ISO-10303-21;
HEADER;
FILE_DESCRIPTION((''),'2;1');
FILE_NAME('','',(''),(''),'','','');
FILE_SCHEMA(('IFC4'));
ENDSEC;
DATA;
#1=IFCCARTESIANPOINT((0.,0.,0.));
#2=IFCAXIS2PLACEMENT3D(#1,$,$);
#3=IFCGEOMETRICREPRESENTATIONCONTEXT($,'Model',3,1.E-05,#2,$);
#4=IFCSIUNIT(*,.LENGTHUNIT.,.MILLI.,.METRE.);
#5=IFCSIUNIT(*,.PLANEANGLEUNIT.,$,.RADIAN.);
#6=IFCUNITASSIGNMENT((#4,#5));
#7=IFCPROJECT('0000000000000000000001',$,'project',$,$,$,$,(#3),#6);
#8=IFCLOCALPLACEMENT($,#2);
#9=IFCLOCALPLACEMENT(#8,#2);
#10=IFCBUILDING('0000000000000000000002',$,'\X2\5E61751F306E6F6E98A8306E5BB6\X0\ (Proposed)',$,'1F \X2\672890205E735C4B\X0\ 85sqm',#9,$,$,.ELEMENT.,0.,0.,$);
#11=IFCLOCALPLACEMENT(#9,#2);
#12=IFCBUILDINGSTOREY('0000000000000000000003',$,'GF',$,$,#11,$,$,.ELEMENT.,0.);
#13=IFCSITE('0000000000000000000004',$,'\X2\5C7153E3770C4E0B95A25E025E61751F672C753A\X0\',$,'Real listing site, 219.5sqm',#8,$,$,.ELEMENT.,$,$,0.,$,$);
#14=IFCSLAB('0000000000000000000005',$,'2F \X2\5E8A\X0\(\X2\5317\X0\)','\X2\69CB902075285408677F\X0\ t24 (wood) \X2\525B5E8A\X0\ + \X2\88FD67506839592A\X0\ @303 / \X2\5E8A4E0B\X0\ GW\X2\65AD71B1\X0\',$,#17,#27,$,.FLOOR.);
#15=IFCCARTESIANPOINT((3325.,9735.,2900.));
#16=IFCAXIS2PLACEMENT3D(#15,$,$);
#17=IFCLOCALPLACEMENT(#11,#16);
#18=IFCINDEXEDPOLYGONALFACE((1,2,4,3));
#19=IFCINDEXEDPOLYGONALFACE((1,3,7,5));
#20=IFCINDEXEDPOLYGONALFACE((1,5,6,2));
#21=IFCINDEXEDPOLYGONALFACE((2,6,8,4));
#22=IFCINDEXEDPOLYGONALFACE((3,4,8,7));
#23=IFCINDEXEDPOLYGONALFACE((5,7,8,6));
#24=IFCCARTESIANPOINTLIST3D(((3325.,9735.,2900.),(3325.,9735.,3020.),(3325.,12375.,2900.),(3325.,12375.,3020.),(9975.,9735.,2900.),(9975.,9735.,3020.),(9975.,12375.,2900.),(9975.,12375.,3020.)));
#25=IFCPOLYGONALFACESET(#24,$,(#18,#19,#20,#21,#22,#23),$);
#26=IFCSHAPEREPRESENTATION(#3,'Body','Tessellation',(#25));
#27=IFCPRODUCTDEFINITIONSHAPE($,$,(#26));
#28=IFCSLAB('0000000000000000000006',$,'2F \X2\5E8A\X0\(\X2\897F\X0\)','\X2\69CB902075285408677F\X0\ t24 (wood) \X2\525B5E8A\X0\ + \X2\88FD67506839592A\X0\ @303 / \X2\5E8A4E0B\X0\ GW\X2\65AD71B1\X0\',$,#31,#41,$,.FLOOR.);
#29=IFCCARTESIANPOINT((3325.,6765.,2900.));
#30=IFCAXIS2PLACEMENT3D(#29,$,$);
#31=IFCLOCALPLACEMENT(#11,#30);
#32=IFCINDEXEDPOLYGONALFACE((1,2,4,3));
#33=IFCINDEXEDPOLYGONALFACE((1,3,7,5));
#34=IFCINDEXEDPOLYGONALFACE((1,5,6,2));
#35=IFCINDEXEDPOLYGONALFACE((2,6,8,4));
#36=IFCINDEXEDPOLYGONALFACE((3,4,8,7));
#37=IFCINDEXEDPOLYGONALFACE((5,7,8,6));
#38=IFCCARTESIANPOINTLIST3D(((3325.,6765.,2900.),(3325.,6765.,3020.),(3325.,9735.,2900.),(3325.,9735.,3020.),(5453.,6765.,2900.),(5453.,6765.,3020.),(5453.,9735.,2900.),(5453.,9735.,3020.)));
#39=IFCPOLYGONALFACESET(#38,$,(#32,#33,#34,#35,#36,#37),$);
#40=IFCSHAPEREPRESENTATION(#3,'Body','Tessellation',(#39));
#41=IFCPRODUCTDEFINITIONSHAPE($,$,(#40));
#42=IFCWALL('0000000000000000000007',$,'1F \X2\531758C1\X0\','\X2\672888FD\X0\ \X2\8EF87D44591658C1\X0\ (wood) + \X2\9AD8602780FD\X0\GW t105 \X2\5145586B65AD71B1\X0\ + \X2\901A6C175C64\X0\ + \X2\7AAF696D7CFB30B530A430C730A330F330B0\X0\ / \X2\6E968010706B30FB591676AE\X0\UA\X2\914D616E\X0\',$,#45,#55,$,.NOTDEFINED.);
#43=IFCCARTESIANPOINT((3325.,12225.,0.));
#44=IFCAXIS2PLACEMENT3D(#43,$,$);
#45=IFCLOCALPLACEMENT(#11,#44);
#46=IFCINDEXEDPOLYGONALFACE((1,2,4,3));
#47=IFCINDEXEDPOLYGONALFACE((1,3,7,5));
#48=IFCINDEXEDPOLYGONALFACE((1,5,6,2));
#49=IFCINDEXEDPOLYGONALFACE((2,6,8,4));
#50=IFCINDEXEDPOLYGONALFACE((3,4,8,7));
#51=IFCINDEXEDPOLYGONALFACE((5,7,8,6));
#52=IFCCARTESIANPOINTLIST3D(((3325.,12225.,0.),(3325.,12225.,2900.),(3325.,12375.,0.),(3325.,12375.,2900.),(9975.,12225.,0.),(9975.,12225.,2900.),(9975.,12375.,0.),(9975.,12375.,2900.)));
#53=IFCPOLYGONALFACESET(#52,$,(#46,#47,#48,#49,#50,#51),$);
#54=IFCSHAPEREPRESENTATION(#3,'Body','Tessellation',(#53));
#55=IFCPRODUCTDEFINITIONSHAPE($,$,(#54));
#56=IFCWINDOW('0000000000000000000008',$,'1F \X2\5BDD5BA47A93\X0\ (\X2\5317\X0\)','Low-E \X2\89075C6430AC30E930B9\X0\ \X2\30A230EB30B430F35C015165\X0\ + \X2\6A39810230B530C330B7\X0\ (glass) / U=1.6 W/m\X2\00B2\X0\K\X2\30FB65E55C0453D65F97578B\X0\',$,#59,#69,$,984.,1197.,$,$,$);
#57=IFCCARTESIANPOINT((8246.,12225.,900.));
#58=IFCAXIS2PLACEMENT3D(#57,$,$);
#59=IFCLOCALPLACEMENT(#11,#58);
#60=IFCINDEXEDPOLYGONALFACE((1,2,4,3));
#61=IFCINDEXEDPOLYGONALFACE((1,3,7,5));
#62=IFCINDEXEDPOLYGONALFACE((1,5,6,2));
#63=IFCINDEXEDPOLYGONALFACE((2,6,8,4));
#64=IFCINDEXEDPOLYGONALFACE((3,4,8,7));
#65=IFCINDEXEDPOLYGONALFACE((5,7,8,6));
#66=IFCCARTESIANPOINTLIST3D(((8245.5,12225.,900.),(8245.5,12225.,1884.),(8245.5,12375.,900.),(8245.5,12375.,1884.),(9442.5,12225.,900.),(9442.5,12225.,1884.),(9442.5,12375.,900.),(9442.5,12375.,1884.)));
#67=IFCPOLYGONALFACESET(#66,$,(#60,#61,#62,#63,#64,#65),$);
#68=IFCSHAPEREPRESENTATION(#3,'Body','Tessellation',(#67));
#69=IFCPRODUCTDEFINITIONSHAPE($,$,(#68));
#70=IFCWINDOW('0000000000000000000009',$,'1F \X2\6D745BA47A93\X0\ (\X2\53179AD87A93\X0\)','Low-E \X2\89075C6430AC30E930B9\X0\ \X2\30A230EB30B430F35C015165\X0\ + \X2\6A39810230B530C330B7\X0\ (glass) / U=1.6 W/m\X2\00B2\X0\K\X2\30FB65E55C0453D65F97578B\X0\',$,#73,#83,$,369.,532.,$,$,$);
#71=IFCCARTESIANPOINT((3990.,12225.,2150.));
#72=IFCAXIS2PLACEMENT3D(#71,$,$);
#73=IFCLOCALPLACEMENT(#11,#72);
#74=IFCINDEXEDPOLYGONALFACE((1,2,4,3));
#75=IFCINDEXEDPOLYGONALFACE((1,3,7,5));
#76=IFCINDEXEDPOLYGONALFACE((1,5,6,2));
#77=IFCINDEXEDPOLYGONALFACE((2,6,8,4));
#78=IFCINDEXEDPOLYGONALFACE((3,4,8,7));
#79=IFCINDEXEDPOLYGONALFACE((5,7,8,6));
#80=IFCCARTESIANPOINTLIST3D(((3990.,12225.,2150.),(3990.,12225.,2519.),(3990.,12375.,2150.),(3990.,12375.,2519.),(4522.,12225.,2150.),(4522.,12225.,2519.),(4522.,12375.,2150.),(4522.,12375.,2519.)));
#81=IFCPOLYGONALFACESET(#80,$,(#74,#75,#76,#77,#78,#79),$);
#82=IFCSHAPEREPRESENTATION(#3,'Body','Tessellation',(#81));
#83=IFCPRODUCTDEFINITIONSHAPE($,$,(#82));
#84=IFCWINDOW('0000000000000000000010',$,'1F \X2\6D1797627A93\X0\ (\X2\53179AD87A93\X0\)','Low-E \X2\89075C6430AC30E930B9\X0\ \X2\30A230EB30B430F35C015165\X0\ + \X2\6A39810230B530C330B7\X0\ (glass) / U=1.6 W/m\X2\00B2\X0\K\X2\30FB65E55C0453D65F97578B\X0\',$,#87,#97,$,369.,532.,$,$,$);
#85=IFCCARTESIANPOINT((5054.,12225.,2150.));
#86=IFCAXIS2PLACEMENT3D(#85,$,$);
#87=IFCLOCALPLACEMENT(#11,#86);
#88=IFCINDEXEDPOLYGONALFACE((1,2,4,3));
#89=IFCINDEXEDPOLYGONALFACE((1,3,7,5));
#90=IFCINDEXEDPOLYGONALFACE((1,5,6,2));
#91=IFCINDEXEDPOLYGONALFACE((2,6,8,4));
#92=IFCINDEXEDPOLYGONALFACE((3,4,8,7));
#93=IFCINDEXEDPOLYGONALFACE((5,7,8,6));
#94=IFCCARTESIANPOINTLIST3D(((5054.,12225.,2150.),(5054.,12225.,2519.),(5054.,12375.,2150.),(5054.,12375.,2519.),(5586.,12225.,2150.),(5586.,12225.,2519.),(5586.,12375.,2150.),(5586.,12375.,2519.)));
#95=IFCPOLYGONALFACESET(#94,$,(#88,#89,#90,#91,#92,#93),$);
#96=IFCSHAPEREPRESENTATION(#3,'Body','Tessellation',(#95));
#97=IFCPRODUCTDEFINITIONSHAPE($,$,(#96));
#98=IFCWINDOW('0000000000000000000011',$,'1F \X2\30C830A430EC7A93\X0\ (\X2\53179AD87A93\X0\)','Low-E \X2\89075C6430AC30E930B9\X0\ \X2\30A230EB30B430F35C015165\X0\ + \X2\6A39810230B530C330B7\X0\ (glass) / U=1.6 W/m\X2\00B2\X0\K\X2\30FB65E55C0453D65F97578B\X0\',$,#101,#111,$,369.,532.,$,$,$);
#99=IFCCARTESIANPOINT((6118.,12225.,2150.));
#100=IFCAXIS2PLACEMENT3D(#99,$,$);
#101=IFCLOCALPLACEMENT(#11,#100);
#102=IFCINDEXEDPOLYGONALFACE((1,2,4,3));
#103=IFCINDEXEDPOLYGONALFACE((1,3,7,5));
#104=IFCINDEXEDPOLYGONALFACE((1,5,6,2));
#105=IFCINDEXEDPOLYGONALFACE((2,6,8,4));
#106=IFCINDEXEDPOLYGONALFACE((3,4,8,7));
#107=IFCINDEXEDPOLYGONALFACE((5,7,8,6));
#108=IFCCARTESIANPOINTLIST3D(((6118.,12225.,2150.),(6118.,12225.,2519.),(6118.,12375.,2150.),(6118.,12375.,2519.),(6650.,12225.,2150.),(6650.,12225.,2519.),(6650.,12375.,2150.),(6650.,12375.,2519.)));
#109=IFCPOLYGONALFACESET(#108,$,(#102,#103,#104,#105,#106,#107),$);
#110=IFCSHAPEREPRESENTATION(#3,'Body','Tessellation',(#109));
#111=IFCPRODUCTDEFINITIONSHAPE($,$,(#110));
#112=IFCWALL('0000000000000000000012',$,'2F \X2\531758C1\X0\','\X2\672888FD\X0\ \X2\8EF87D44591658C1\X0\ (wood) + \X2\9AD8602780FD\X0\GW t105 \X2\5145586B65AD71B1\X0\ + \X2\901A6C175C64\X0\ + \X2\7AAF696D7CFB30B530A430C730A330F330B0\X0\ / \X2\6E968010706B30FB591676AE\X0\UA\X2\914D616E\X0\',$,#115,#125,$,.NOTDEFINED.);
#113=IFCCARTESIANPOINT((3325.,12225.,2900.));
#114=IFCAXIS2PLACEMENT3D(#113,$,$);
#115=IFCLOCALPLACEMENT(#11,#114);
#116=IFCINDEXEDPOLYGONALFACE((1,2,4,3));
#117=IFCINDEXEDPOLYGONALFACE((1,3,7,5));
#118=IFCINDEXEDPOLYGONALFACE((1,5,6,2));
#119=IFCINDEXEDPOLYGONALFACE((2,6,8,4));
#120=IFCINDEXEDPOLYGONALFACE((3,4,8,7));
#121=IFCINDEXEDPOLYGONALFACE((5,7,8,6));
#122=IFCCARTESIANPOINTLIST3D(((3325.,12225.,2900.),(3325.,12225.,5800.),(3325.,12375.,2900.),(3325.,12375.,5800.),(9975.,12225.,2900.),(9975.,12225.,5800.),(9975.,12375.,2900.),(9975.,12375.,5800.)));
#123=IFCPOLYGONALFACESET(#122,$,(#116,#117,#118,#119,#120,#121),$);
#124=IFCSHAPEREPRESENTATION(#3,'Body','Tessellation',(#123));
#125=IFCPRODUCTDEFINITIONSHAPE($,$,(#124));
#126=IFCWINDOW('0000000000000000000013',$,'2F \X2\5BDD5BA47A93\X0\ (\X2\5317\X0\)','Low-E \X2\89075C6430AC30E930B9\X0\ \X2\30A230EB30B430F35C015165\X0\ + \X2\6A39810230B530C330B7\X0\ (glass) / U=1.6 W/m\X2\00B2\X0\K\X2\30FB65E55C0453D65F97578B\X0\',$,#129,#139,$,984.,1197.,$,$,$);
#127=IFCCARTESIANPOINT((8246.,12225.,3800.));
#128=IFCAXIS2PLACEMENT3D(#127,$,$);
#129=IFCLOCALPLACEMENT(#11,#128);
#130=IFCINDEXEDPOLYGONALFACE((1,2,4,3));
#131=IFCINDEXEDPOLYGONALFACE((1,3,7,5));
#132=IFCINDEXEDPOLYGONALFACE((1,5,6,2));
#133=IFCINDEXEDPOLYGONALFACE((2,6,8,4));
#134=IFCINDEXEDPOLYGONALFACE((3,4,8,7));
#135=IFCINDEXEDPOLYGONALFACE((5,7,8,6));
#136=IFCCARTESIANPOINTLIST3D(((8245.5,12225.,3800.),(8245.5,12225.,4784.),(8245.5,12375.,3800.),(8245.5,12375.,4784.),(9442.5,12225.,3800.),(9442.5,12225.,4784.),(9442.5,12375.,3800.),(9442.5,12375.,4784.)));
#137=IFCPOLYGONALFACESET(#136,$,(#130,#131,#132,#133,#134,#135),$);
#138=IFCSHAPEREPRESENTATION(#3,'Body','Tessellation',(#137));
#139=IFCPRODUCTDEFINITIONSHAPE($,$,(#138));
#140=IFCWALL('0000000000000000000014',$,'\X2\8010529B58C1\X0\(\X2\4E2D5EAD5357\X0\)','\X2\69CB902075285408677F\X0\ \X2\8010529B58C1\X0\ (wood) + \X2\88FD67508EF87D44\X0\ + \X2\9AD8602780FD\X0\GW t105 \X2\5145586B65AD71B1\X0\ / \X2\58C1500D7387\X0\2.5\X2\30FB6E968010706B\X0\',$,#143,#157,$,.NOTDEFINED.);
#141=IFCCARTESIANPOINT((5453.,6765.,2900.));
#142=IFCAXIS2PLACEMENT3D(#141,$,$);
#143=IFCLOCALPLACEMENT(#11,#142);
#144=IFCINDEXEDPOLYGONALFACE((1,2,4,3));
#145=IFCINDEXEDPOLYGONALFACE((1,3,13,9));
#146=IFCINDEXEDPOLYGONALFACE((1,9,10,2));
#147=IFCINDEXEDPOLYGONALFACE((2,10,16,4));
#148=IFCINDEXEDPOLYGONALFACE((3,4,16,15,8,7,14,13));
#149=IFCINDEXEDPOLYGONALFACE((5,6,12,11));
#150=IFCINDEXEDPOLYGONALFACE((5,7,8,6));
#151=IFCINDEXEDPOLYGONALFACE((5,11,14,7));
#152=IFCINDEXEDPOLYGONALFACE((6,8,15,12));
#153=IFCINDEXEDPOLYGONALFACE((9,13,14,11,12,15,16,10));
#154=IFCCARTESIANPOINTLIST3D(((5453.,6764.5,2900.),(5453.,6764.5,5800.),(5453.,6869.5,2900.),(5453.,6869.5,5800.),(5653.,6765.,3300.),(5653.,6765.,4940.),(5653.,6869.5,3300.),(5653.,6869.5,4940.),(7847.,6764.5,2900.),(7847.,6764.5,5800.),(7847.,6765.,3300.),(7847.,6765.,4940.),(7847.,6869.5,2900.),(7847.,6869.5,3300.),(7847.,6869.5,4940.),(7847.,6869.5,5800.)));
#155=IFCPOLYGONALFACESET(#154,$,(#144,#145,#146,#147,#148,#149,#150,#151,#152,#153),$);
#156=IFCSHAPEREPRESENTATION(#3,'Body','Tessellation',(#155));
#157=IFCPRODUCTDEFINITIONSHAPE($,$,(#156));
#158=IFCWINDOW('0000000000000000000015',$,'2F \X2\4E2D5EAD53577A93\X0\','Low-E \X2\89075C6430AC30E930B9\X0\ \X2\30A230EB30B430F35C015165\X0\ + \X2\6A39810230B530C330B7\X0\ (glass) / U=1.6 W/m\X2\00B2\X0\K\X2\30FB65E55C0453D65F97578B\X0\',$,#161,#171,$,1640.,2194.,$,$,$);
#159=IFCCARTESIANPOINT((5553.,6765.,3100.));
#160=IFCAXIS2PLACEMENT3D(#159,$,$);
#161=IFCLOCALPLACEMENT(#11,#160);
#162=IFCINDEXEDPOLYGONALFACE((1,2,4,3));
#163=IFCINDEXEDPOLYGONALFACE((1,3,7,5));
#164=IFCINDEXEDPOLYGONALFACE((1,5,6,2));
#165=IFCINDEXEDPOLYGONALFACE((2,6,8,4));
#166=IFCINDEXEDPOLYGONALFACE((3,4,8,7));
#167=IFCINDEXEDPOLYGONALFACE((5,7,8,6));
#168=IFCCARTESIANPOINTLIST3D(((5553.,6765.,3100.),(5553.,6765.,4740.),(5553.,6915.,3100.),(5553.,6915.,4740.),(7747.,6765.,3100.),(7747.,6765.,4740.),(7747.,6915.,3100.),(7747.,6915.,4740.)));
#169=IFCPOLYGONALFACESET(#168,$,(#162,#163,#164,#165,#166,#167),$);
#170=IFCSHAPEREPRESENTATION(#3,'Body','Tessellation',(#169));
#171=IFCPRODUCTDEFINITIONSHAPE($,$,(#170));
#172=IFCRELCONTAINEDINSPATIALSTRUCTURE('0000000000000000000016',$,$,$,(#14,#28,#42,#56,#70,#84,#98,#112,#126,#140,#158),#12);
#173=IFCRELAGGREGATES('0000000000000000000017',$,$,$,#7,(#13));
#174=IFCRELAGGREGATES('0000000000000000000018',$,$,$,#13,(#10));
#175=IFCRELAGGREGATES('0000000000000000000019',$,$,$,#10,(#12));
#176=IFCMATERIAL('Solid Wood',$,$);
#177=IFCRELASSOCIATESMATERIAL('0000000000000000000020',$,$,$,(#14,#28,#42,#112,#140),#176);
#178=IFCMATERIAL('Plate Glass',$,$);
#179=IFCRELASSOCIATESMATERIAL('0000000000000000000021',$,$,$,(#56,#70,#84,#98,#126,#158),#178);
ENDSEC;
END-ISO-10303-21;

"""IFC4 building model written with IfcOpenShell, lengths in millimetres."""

from ifc_helpers import new_model, si_unit, frame, frame_2d, origin, place, context, project, spatial, rectangle, extrude, material, element, fill, save


model = new_model("IFC4")

# Units and contexts
model_context = context("Model", 3, precision=1e-05, world=origin())
ifc_project = project(units=[si_unit("LENGTHUNIT", "METRE", prefix="MILLI"), si_unit("PLANEANGLEUNIT", "RADIAN")], contexts=[model_context])

# Site, building, storey
site_placement = place(None, origin())
site = spatial("IfcSite", under=ifc_project, at=site_placement, Name="山口県下関市幡生本町", ObjectType="Real listing site, 219.5sqm", CompositionType="ELEMENT", RefElevation=0.0)
building_placement = place(site_placement, origin())
building = spatial("IfcBuilding", under=site, at=building_placement, Name="幡生の潮風の家 (Proposed)", ObjectType="1F 木造平屋 85sqm", CompositionType="ELEMENT", ElevationOfRefHeight=0.0, ElevationOfTerrain=0.0)
storey_placement = place(building_placement, origin())
storey = spatial("IfcBuildingStorey", under=building, at=storey_placement, Name="GF", CompositionType="ELEMENT", Elevation=0.0)

# Slabs
ifc_material_1 = material(Name="Solid Wood")
slab_1_placement = place(storey_placement, frame((3325.0, 9735.0, 2900.0)))
element("IfcSlab", 1, at=slab_1_placement, inside=storey, material=ifc_material_1, Name="2F 床(北)", Description="構造用合板 t24 (wood) 剛床 + 製材根太 @303 / 床下 GW断熱", PredefinedType="FLOOR", context=model_context, shape_type="SweptSolid", body=[
    extrude(rectangle(XDim=6650.0, YDim=2640.0, at=frame_2d((3325.0, 1320.0))), frame((3325.0, 9735.0, 2900.0)), (0.0, 0.0, 1.0), 120.0),
])
slab_2_placement = place(storey_placement, frame((3325.0, 6765.0, 2900.0)))
element("IfcSlab", 2, at=slab_2_placement, inside=storey, material=ifc_material_1, Name="2F 床(西)", Description="構造用合板 t24 (wood) 剛床 + 製材根太 @303 / 床下 GW断熱", PredefinedType="FLOOR", context=model_context, shape_type="SweptSolid", body=[
    extrude(rectangle(XDim=2128.0, YDim=2970.0, at=frame_2d((1064.0, 1485.0))), frame((3325.0, 6765.0, 2900.0)), (0.0, 0.0, 1.0), 120.0),
])

# Wall, openings, windows
wall_1_placement = place(storey_placement, frame((3325.0, 12225.0, 0.0)))
wall_1 = element("IfcWall", 3, at=wall_1_placement, inside=storey, material=ifc_material_1, Name="1F 北壁", Description="木製 軸組外壁 (wood) + 高性能GW t105 充填断熱 + 通気層 + 窯業系サイディング / 準耐火・外皮UA配慮", PredefinedType="NOTDEFINED", context=model_context, shape_type="SweptSolid", body=[
    extrude(rectangle(XDim=6650.0, YDim=150.0, at=frame_2d((3325.0, 75.0))), frame((3325.0, 12225.0, 0.0)), (0.0, 0.0, 1.0), 2900.0),
])
opening_1_placement = place(storey_placement, frame((8246.0, 12225.0, 900.0)))
opening_1 = element("IfcOpeningElement", 4, at=opening_1_placement, cuts=wall_1, PredefinedType="NOTDEFINED", context=model_context, shape_type="SweptSolid", body=[
    extrude(rectangle(XDim=1197.0, YDim=150.0, at=frame_2d((598.0, 75.0))), frame((8246.0, 12225.0, 900.0)), (0.0, 0.0, 1.0), 984.0),
])
opening_2_placement = place(storey_placement, frame((3990.0, 12225.0, 2150.0)))
opening_2 = element("IfcOpeningElement", 5, at=opening_2_placement, cuts=wall_1, PredefinedType="NOTDEFINED", context=model_context, shape_type="SweptSolid", body=[
    extrude(rectangle(XDim=532.0, YDim=150.0, at=frame_2d((266.0, 75.0))), frame((3990.0, 12225.0, 2150.0)), (0.0, 0.0, 1.0), 369.0),
])
opening_3_placement = place(storey_placement, frame((5054.0, 12225.0, 2150.0)))
opening_3 = element("IfcOpeningElement", 6, at=opening_3_placement, cuts=wall_1, PredefinedType="NOTDEFINED", context=model_context, shape_type="SweptSolid", body=[
    extrude(rectangle(XDim=532.0, YDim=150.0, at=frame_2d((266.0, 75.0))), frame((5054.0, 12225.0, 2150.0)), (0.0, 0.0, 1.0), 369.0),
])
opening_4_placement = place(storey_placement, frame((6118.0, 12225.0, 2150.0)))
opening_4 = element("IfcOpeningElement", 7, at=opening_4_placement, cuts=wall_1, PredefinedType="NOTDEFINED", context=model_context, shape_type="SweptSolid", body=[
    extrude(rectangle(XDim=532.0, YDim=150.0, at=frame_2d((266.0, 75.0))), frame((6118.0, 12225.0, 2150.0)), (0.0, 0.0, 1.0), 369.0),
])
ifc_material_2 = material(Name="Plate Glass")
window_1_placement = place(storey_placement, frame((8246.0, 12225.0, 900.0)))
window_1 = element("IfcWindow", 8, at=window_1_placement, inside=storey, material=ifc_material_2, Name="1F 寝室窓 (北)", Description="Low-E 複層ガラス アルゴン封入 + 樹脂サッシ (glass) / U=1.6 W/m²K・日射取得型", OverallHeight=984.0, OverallWidth=1197.0, context=model_context, shape_type="SweptSolid", body=[
    extrude(rectangle(XDim=1197.0, YDim=150.0, at=frame_2d((598.0, 75.0))), frame((8246.0, 12225.0, 900.0)), (0.0, 0.0, 1.0), 984.0),
])
fill(opening_1, window_1)
window_2_placement = place(storey_placement, frame((3990.0, 12225.0, 2150.0)))
window_2 = element("IfcWindow", 9, at=window_2_placement, inside=storey, material=ifc_material_2, Name="1F 浴室窓 (北高窓)", Description="Low-E 複層ガラス アルゴン封入 + 樹脂サッシ (glass) / U=1.6 W/m²K・日射取得型", OverallHeight=369.0, OverallWidth=532.0, context=model_context, shape_type="SweptSolid", body=[
    extrude(rectangle(XDim=532.0, YDim=150.0, at=frame_2d((266.0, 75.0))), frame((3990.0, 12225.0, 2150.0)), (0.0, 0.0, 1.0), 369.0),
])
fill(opening_2, window_2)
window_3_placement = place(storey_placement, frame((5054.0, 12225.0, 2150.0)))
window_3 = element("IfcWindow", 10, at=window_3_placement, inside=storey, material=ifc_material_2, Name="1F 洗面窓 (北高窓)", Description="Low-E 複層ガラス アルゴン封入 + 樹脂サッシ (glass) / U=1.6 W/m²K・日射取得型", OverallHeight=369.0, OverallWidth=532.0, context=model_context, shape_type="SweptSolid", body=[
    extrude(rectangle(XDim=532.0, YDim=150.0, at=frame_2d((266.0, 75.0))), frame((5054.0, 12225.0, 2150.0)), (0.0, 0.0, 1.0), 369.0),
])
fill(opening_3, window_3)
window_4_placement = place(storey_placement, frame((6118.0, 12225.0, 2150.0)))
window_4 = element("IfcWindow", 11, at=window_4_placement, inside=storey, material=ifc_material_2, Name="1F トイレ窓 (北高窓)", Description="Low-E 複層ガラス アルゴン封入 + 樹脂サッシ (glass) / U=1.6 W/m²K・日射取得型", OverallHeight=369.0, OverallWidth=532.0, context=model_context, shape_type="SweptSolid", body=[
    extrude(rectangle(XDim=532.0, YDim=150.0, at=frame_2d((266.0, 75.0))), frame((6118.0, 12225.0, 2150.0)), (0.0, 0.0, 1.0), 369.0),
])
fill(opening_4, window_4)

# Walls, openings, windows
wall_2_placement = place(storey_placement, frame((3325.0, 12225.0, 2900.0)))
wall_2 = element("IfcWall", 12, at=wall_2_placement, inside=storey, material=ifc_material_1, Name="2F 北壁", Description="木製 軸組外壁 (wood) + 高性能GW t105 充填断熱 + 通気層 + 窯業系サイディング / 準耐火・外皮UA配慮", PredefinedType="NOTDEFINED", context=model_context, shape_type="SweptSolid", body=[
    extrude(rectangle(XDim=6650.0, YDim=150.0, at=frame_2d((3325.0, 75.0))), frame((3325.0, 12225.0, 2900.0)), (0.0, 0.0, 1.0), 2900.0),
])
opening_5_placement = place(storey_placement, frame((8246.0, 12225.0, 3800.0)))
opening_5 = element("IfcOpeningElement", 13, at=opening_5_placement, cuts=wall_2, PredefinedType="NOTDEFINED", context=model_context, shape_type="SweptSolid", body=[
    extrude(rectangle(XDim=1197.0, YDim=150.0, at=frame_2d((598.0, 75.0))), frame((8246.0, 12225.0, 3800.0)), (0.0, 0.0, 1.0), 984.0),
])
window_5_placement = place(storey_placement, frame((8246.0, 12225.0, 3800.0)))
window_5 = element("IfcWindow", 14, at=window_5_placement, inside=storey, material=ifc_material_2, Name="2F 寝室窓 (北)", Description="Low-E 複層ガラス アルゴン封入 + 樹脂サッシ (glass) / U=1.6 W/m²K・日射取得型", OverallHeight=984.0, OverallWidth=1197.0, context=model_context, shape_type="SweptSolid", body=[
    extrude(rectangle(XDim=1197.0, YDim=150.0, at=frame_2d((598.0, 75.0))), frame((8246.0, 12225.0, 3800.0)), (0.0, 0.0, 1.0), 984.0),
])
fill(opening_5, window_5)
wall_3_placement = place(storey_placement, frame((5453.0, 6765.0, 2900.0)))
wall_3 = element("IfcWall", 15, at=wall_3_placement, inside=storey, material=ifc_material_1, Name="耐力壁(中庭南)", Description="構造用合板 耐力壁 (wood) + 製材軸組 + 高性能GW t105 充填断熱 / 壁倍率2.5・準耐火", PredefinedType="NOTDEFINED", context=model_context, shape_type="SweptSolid", body=[
    extrude(rectangle(XDim=2394.0, YDim=105.0, at=frame_2d((1197.0, 52.0))), frame((5453.0, 6765.0, 2900.0)), (0.0, 0.0, 1.0), 2900.0),
])
opening_6_placement = place(storey_placement, frame((5553.0, 6765.0, 3100.0)))
opening_6 = element("IfcOpeningElement", 16, at=opening_6_placement, cuts=wall_3, PredefinedType="NOTDEFINED", context=model_context, shape_type="SweptSolid", body=[
    extrude(rectangle(XDim=2194.0, YDim=150.0, at=frame_2d((1097.0, 75.0))), frame((5553.0, 6765.0, 3100.0)), (0.0, 0.0, 1.0), 1640.0),
])
window_6_placement = place(storey_placement, frame((5553.0, 6765.0, 3100.0)))
window_6 = element("IfcWindow", 17, at=window_6_placement, inside=storey, material=ifc_material_2, Name="2F 中庭南窓", Description="Low-E 複層ガラス アルゴン封入 + 樹脂サッシ (glass) / U=1.6 W/m²K・日射取得型", OverallHeight=1640.0, OverallWidth=2194.0, context=model_context, shape_type="SweptSolid", body=[
    extrude(rectangle(XDim=2194.0, YDim=150.0, at=frame_2d((1097.0, 75.0))), frame((5553.0, 6765.0, 3100.0)), (0.0, 0.0, 1.0), 1640.0),
])
fill(opening_6, window_6)

save(model, "model.ifc")
